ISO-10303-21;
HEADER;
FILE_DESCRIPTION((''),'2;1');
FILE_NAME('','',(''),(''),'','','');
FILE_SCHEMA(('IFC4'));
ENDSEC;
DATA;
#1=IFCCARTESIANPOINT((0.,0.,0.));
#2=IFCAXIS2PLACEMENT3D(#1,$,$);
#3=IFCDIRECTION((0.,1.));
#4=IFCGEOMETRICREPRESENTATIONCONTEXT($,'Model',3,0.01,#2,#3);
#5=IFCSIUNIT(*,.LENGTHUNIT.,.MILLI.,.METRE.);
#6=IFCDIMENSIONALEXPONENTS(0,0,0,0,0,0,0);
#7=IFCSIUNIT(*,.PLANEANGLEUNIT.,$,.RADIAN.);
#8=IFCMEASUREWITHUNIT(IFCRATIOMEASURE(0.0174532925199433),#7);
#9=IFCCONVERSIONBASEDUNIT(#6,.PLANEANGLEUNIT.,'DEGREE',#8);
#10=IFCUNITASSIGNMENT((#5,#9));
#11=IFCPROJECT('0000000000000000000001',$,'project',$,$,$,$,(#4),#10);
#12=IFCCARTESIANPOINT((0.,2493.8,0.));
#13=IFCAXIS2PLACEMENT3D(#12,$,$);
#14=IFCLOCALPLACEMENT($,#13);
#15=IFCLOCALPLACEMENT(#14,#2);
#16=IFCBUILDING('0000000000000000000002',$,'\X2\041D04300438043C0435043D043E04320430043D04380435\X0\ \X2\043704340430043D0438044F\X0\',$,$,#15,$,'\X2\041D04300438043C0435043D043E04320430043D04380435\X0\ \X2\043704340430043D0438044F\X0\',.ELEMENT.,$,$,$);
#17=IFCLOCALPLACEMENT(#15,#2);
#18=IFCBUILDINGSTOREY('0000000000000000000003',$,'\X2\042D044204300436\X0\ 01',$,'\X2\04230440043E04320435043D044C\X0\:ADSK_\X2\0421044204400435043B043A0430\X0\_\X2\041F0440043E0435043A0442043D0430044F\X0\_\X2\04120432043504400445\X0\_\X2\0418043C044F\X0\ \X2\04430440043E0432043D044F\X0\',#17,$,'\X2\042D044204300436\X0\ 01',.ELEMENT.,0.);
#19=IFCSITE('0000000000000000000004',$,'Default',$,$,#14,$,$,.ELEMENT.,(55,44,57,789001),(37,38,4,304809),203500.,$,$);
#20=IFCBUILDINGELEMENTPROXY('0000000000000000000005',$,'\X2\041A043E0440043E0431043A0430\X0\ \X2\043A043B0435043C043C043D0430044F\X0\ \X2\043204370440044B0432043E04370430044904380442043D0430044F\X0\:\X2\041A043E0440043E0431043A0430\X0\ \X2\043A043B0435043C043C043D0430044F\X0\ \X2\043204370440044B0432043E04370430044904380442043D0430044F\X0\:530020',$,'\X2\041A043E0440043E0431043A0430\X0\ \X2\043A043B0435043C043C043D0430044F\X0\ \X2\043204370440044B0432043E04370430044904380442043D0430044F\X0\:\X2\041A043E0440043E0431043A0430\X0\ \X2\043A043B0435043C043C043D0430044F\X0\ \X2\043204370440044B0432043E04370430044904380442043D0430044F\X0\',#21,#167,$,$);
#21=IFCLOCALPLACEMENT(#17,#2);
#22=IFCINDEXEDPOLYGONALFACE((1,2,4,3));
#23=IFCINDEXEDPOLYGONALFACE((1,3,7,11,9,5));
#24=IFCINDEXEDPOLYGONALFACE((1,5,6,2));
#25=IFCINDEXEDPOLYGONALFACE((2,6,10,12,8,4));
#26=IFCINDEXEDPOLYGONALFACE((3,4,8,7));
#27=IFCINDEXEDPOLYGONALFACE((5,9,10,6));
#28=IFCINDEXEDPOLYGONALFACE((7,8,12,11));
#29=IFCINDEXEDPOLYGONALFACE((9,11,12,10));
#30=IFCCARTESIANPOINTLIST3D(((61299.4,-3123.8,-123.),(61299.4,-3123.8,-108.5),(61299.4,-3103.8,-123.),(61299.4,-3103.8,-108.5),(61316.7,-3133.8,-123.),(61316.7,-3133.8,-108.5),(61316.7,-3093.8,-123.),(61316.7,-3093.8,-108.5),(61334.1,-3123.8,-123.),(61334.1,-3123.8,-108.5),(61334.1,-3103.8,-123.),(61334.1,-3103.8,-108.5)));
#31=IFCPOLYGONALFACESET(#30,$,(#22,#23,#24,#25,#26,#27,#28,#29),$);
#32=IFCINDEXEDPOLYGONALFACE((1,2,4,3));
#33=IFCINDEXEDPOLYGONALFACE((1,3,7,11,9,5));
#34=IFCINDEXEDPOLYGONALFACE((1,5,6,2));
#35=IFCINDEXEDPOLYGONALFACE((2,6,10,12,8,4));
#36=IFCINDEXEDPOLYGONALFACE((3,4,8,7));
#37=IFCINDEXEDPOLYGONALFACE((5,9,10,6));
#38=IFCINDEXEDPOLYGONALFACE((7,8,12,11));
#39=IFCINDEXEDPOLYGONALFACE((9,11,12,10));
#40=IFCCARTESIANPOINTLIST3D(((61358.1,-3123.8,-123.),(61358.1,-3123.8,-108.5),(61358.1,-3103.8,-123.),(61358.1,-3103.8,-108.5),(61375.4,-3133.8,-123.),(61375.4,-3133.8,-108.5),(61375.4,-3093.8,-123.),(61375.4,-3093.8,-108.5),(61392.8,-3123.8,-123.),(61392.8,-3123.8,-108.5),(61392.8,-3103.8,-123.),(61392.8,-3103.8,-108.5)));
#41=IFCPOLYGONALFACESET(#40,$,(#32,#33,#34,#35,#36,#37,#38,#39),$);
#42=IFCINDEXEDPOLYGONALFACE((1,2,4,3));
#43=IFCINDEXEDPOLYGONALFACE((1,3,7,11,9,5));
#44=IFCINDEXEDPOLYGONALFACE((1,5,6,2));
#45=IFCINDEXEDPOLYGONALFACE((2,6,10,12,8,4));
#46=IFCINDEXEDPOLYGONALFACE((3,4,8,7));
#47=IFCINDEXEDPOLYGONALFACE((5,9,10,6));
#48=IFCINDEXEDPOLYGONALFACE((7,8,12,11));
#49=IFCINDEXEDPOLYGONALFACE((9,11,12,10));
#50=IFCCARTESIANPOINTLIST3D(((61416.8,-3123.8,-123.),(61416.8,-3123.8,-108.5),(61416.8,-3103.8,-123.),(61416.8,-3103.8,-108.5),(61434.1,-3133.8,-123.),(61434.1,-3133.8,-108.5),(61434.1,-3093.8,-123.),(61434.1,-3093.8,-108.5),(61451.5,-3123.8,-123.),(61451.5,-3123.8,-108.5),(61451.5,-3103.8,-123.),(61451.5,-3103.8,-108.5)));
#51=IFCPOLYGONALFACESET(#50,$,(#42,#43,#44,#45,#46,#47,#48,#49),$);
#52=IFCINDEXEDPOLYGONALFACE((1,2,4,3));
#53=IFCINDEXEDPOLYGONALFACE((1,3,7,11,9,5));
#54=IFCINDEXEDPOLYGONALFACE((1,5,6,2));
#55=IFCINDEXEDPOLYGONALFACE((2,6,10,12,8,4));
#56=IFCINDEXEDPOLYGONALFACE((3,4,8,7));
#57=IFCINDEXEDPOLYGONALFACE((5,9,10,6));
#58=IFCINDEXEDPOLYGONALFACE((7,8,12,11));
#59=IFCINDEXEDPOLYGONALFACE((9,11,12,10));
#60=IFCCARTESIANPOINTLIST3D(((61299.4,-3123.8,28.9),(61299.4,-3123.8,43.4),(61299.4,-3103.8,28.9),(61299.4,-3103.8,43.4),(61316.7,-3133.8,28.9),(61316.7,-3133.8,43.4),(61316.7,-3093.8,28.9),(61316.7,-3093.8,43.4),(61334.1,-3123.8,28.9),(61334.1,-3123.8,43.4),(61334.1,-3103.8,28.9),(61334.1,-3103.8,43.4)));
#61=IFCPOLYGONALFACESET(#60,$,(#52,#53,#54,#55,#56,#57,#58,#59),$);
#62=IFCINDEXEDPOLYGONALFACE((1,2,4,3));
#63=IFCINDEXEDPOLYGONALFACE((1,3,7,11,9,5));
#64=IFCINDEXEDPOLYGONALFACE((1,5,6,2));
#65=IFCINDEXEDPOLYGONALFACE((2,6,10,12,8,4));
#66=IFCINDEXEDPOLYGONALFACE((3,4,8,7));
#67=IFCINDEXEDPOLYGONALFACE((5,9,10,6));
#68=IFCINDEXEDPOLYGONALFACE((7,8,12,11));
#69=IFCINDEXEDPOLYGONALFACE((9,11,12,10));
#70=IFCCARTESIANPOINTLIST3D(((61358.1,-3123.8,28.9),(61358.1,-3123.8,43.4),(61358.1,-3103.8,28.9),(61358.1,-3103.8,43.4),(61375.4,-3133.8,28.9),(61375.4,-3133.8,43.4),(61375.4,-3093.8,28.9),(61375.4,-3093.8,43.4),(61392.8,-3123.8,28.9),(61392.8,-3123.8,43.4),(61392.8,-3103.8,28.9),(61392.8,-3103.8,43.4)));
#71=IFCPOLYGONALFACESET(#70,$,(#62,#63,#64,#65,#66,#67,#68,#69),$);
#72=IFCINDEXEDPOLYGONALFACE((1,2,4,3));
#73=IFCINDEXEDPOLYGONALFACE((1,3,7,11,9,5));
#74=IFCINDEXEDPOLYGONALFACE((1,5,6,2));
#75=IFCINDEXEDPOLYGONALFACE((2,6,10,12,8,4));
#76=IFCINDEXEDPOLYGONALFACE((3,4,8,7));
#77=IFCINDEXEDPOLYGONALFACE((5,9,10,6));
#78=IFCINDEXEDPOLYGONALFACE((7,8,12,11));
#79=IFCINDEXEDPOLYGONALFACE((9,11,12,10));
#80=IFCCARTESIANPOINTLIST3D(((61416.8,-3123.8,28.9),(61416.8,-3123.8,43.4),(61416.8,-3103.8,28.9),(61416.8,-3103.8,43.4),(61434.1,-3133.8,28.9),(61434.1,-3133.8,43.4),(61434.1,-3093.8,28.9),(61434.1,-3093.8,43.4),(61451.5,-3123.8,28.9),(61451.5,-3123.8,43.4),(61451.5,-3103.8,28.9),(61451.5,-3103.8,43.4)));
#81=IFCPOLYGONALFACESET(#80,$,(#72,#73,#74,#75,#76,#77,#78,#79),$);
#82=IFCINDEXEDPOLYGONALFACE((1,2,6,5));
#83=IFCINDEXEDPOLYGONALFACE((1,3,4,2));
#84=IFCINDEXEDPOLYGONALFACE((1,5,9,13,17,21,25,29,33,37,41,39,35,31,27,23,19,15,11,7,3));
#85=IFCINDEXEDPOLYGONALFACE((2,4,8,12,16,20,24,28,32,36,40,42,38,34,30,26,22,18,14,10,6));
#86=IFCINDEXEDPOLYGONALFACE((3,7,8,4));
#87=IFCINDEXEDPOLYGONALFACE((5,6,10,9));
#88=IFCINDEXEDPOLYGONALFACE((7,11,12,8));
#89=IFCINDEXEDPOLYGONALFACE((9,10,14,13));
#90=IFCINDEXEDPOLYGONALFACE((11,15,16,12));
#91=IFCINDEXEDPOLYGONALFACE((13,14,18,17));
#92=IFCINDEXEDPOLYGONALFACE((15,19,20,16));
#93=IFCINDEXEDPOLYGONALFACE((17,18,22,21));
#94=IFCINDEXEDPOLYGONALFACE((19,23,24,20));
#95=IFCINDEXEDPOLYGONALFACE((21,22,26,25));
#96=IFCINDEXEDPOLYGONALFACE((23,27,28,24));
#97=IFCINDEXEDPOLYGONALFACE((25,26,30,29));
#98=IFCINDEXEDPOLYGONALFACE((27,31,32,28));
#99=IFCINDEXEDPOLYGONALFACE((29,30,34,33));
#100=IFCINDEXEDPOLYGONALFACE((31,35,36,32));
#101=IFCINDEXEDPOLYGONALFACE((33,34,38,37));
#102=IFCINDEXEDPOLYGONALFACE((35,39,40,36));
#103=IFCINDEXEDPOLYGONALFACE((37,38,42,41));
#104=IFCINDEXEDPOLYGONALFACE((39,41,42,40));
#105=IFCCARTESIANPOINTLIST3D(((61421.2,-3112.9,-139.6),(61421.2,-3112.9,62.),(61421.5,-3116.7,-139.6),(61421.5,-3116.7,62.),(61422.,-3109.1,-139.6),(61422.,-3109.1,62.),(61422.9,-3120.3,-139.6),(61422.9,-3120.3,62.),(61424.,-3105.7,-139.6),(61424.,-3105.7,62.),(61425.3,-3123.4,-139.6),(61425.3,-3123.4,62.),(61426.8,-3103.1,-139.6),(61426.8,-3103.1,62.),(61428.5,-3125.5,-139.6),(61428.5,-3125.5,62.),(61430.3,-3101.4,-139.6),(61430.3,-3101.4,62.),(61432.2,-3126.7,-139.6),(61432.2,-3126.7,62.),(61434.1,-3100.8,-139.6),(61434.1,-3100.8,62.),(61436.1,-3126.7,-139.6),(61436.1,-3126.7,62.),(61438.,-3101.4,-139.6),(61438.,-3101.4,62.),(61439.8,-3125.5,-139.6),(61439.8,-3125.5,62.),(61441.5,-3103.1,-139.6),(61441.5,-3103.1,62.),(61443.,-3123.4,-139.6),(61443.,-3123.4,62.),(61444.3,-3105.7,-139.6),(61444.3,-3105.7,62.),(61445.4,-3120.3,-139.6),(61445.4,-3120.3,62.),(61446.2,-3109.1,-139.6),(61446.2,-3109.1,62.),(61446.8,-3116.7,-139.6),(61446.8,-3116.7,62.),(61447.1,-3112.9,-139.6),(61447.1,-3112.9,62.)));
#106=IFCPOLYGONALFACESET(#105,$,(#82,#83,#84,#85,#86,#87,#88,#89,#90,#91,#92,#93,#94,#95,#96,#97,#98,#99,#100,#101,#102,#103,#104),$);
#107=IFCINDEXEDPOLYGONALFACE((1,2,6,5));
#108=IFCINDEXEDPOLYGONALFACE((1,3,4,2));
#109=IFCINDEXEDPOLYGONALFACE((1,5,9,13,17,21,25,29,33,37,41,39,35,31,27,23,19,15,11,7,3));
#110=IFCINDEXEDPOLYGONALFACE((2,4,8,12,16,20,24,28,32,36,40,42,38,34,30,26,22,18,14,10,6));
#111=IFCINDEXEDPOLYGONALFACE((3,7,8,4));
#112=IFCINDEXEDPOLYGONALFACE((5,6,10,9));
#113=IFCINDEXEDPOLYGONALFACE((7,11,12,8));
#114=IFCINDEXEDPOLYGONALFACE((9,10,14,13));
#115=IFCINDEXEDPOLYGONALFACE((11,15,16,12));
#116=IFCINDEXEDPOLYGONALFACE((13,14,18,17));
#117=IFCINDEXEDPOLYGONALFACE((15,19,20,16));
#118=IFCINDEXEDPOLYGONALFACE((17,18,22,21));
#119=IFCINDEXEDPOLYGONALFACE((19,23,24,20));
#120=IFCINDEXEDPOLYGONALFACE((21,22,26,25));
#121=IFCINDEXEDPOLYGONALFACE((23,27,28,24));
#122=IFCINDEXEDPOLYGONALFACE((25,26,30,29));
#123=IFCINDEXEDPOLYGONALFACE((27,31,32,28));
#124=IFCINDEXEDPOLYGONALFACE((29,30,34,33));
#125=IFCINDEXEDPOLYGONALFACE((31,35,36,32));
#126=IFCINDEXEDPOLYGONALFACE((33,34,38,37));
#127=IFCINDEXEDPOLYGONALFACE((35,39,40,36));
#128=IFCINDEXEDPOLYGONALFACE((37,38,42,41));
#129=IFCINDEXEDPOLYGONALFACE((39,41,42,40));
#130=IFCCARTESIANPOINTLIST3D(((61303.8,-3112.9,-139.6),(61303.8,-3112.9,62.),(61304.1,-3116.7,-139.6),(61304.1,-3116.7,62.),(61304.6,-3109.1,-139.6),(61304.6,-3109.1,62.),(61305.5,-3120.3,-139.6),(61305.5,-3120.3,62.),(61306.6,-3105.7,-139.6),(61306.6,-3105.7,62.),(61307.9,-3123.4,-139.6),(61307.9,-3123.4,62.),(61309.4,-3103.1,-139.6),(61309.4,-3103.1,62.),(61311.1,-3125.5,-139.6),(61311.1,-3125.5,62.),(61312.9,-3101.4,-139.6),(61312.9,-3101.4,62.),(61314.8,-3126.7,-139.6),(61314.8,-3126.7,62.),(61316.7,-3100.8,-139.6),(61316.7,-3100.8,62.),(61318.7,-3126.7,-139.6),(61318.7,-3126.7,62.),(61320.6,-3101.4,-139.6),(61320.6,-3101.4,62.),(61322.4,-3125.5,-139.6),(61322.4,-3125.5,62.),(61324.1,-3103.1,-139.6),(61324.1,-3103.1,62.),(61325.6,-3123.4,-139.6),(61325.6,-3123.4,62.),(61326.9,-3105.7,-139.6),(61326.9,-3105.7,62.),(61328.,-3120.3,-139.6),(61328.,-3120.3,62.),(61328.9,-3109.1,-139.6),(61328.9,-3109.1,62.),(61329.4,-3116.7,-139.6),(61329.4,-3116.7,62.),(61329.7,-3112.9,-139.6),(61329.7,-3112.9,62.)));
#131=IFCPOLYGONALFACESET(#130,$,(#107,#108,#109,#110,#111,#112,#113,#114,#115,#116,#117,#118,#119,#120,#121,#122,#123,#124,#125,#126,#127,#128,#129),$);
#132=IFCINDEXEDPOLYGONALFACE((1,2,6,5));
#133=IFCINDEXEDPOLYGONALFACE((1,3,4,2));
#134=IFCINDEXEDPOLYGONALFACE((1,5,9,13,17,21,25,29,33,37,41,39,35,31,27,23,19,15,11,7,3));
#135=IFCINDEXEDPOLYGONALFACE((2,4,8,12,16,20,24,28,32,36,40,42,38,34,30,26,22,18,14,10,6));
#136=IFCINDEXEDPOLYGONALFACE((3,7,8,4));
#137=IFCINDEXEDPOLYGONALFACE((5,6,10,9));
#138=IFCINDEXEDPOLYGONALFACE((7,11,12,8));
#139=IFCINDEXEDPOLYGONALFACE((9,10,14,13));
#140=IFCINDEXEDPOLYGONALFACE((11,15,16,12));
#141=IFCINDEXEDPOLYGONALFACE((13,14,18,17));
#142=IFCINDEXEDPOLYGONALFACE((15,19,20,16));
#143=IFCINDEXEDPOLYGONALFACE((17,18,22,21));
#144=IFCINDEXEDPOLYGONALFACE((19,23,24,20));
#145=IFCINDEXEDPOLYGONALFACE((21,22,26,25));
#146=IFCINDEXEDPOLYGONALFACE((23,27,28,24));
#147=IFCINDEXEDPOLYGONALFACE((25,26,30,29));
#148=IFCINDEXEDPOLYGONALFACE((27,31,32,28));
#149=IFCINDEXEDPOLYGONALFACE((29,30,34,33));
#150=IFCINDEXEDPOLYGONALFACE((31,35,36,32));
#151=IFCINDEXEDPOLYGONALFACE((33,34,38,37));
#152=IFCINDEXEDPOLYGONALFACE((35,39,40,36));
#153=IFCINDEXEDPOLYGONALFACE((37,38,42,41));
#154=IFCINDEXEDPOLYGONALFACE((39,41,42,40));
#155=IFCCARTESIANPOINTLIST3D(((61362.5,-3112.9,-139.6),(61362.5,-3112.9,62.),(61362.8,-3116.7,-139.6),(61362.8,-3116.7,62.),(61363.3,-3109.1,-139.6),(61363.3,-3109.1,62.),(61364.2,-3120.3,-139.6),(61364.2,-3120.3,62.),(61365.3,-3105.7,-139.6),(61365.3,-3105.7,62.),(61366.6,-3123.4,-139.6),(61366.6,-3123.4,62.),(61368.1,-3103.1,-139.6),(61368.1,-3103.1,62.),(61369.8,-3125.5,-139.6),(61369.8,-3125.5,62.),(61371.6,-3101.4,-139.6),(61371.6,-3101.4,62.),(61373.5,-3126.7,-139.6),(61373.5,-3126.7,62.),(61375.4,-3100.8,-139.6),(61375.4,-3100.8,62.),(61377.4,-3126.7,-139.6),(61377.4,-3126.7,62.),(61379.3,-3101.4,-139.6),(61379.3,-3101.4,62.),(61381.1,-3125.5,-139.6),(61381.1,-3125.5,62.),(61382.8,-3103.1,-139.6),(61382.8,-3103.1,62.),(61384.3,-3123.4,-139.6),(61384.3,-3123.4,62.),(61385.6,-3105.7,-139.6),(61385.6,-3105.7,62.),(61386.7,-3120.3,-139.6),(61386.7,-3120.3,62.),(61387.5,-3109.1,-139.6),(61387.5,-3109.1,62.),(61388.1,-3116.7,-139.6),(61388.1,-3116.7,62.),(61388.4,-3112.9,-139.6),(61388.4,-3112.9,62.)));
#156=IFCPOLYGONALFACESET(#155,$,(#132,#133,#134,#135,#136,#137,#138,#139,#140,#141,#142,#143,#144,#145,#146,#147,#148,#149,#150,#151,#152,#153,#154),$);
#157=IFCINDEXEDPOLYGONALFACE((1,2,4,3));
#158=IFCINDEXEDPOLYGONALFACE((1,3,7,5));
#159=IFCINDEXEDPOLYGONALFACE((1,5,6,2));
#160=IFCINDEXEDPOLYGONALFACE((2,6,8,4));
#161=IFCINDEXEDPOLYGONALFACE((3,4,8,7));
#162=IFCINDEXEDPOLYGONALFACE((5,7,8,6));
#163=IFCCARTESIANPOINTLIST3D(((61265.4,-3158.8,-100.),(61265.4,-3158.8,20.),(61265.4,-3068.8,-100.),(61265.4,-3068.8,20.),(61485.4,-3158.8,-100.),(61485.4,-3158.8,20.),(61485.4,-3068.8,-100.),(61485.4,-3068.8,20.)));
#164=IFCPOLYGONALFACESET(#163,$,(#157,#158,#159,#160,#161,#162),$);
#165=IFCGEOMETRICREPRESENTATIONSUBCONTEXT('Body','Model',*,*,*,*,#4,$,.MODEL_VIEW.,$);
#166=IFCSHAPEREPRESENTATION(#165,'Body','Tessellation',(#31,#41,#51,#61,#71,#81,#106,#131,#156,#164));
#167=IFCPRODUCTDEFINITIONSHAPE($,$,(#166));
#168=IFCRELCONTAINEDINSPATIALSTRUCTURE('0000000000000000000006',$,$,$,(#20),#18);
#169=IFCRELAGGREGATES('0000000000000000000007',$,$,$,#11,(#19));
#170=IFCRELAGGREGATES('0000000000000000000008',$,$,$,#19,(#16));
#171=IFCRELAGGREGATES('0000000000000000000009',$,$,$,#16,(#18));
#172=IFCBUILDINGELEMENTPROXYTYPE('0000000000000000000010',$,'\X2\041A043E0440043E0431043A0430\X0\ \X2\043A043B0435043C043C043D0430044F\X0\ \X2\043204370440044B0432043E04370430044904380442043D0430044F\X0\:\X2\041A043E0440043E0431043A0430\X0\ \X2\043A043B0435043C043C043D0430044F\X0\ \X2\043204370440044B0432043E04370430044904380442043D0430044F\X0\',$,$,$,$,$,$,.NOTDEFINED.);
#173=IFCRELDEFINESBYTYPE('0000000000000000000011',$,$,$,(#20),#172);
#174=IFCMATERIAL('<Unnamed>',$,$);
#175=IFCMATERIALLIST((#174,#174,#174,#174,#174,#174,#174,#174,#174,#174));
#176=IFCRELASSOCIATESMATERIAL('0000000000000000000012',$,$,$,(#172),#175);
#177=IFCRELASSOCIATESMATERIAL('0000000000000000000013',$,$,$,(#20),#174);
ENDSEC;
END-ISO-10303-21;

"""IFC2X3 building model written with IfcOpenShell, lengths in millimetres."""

from ifc_helpers import new_model, entity, si_unit, converted_unit, direction, frame, frame_2d, origin, place, context, subcontext, project, spatial, polyline, rectangle, circle, outline, extrude, source, transform, mapped, material, material_list, type_object, type_shapes, element, save


model = new_model("IFC2X3")

# Units and contexts
model_context = context("Model", 3, precision=0.01, world=origin(), true_north=direction((0.0, 1.0)))
body_context = subcontext(model_context, "Body", "Model", "MODEL_VIEW")
ifc_project = project(units=[si_unit("LENGTHUNIT", "METRE", prefix="MILLI"), converted_unit("PLANEANGLEUNIT", "DEGREE", entity("IfcRatioMeasure", 0.0174532925199433), si_unit("PLANEANGLEUNIT", "RADIAN"), dimensions=[0, 0, 0, 0, 0, 0, 0])], contexts=[model_context])

# Site, building, storey
site_placement = place(None, frame((0.0, 2493.8, 0.0)))
site = spatial("IfcSite", under=ifc_project, at=site_placement, Name="Default", CompositionType="ELEMENT", RefLatitude=(55, 44, 57, 789001), RefLongitude=(37, 38, 4, 304809), RefElevation=203500.0)
building_placement = place(site_placement, origin())
building = spatial("IfcBuilding", under=site, at=building_placement, Name="Наименование здания", LongName="Наименование здания", CompositionType="ELEMENT")
storey_placement = place(building_placement, origin())
storey = spatial("IfcBuildingStorey", under=building, at=storey_placement, Name="Этаж 01", ObjectType="Уровень:ADSK_Стрелка_Проектная_Вверх_Имя уровня", LongName="Этаж 01", CompositionType="ELEMENT", Elevation=0.0)

# Building element proxy
ifc_material_1 = material(Name="<Unnamed>")
ifc_material_list_1 = material_list([ifc_material_1, ifc_material_1, ifc_material_1, ifc_material_1, ifc_material_1, ifc_material_1, ifc_material_1, ifc_material_1, ifc_material_1, ifc_material_1])
building_element_proxy_type_1 = type_object("IfcBuildingElementProxyType", Name="Коробка клеммная взрывозащитная:Коробка клеммная взрывозащитная", PredefinedType="NOTDEFINED", material=ifc_material_list_1)
shared_shape_1 = source(origin(), body_context, "Body", "SweptSolid", [
    extrude(outline(polyline([(-10.0, -17.3), (10.0, -17.3), (20.0, 0.0), (10.0, 17.3), (-10.0, 17.3), (-20.0, 0.0), (-10.0, -17.3)])), frame((0.0, 58.7, -23.0), z_axis=(0.0, 0.0, 1.0), x_axis=(-1.0, 0.0, 0.0)), (0.0, 0.0, 1.0), 14.4),
    extrude(outline(polyline([(-10.0, -17.3), (10.0, -17.3), (20.0, 0.0), (10.0, 17.3), (-10.0, 17.3), (-20.0, 0.0), (-10.0, -17.3)])), frame((0.0, 0.0, -23.0), z_axis=(0.0, 0.0, 1.0), x_axis=(-1.0, 0.0, 0.0)), (0.0, 0.0, 1.0), 14.4),
    extrude(outline(polyline([(-10.0, -17.3), (10.0, -17.3), (20.0, 0.0), (10.0, 17.3), (-10.0, 17.3), (-20.0, 0.0), (-10.0, -17.3)])), frame((0.0, -58.7, -23.0), z_axis=(0.0, 0.0, 1.0), x_axis=(-1.0, 0.0, 0.0)), (0.0, 0.0, 1.0), 14.4),
    extrude(outline(polyline([(-10.0, -17.3), (10.0, -17.3), (20.0, 0.0), (10.0, 17.3), (-10.0, 17.3), (-20.0, 0.0), (-10.0, -17.3)])), frame((0.0, 58.7, 128.9), z_axis=(0.0, 0.0, 1.0), x_axis=(-1.0, 0.0, 0.0)), (0.0, 0.0, 1.0), 14.4),
    extrude(outline(polyline([(-10.0, -17.3), (10.0, -17.3), (20.0, 0.0), (10.0, 17.3), (-10.0, 17.3), (-20.0, 0.0), (-10.0, -17.3)])), frame((0.0, 0.0, 128.9), z_axis=(0.0, 0.0, 1.0), x_axis=(-1.0, 0.0, 0.0)), (0.0, 0.0, 1.0), 14.4),
    extrude(outline(polyline([(-10.0, -17.3), (10.0, -17.3), (20.0, 0.0), (10.0, 17.3), (-10.0, 17.3), (-20.0, 0.0), (-10.0, -17.3)])), frame((0.0, -58.7, 128.9), z_axis=(0.0, 0.0, 1.0), x_axis=(-1.0, 0.0, 0.0)), (0.0, 0.0, 1.0), 14.4),
    extrude(circle(Radius=13.0, at=frame_2d((0.0, 0.0), x_axis=(1.0, 0.0))), frame((0.0, -58.7, -39.6)), (0.0, 0.0, 1.0), 201.6),
    extrude(circle(Radius=13.0, at=frame_2d((0.0, 0.0), x_axis=(1.0, 0.0))), frame((0.0, 58.7, -39.6)), (0.0, 0.0, 1.0), 201.6),
    extrude(circle(Radius=13.0, at=frame_2d((0.0, 0.0), x_axis=(1.0, 0.0))), frame((0.0, 0.0, -39.6)), (0.0, 0.0, 1.0), 201.6),
    extrude(rectangle(XDim=220.0, YDim=90.0, at=frame_2d((0.0, 0.0), x_axis=(1.0, 0.0))), frame((0.0, 0.0, 0.0), z_axis=(0.0, 0.0, 1.0), x_axis=(0.0, -1.0, 0.0)), (0.0, 0.0, 1.0), 120.0),
])
type_shapes(building_element_proxy_type_1, [shared_shape_1])
for number, where, z_axis, x_axis, name in (
    (1, (61375.4, -3113.8, -100.0), (0.0, 0.0, 1.0), (0.0, 1.0, 0.0), "Коробка клеммная взрывозащитная:Коробка клеммная взрывозащитная:530020"),
):
    element("IfcBuildingElementProxy", number, at=place(storey_placement, frame(where, z_axis=z_axis, x_axis=x_axis)), inside=storey, type_object=building_element_proxy_type_1, material=ifc_material_1, Name=name, ObjectType="Коробка клеммная взрывозащитная:Коробка клеммная взрывозащитная", context=body_context, shape_type="MappedRepresentation", body=[
        mapped(shared_shape_1, transform((0.0, 0.0, 0.0), scale=1.0)),
    ])

save(model, "model.ifc")
